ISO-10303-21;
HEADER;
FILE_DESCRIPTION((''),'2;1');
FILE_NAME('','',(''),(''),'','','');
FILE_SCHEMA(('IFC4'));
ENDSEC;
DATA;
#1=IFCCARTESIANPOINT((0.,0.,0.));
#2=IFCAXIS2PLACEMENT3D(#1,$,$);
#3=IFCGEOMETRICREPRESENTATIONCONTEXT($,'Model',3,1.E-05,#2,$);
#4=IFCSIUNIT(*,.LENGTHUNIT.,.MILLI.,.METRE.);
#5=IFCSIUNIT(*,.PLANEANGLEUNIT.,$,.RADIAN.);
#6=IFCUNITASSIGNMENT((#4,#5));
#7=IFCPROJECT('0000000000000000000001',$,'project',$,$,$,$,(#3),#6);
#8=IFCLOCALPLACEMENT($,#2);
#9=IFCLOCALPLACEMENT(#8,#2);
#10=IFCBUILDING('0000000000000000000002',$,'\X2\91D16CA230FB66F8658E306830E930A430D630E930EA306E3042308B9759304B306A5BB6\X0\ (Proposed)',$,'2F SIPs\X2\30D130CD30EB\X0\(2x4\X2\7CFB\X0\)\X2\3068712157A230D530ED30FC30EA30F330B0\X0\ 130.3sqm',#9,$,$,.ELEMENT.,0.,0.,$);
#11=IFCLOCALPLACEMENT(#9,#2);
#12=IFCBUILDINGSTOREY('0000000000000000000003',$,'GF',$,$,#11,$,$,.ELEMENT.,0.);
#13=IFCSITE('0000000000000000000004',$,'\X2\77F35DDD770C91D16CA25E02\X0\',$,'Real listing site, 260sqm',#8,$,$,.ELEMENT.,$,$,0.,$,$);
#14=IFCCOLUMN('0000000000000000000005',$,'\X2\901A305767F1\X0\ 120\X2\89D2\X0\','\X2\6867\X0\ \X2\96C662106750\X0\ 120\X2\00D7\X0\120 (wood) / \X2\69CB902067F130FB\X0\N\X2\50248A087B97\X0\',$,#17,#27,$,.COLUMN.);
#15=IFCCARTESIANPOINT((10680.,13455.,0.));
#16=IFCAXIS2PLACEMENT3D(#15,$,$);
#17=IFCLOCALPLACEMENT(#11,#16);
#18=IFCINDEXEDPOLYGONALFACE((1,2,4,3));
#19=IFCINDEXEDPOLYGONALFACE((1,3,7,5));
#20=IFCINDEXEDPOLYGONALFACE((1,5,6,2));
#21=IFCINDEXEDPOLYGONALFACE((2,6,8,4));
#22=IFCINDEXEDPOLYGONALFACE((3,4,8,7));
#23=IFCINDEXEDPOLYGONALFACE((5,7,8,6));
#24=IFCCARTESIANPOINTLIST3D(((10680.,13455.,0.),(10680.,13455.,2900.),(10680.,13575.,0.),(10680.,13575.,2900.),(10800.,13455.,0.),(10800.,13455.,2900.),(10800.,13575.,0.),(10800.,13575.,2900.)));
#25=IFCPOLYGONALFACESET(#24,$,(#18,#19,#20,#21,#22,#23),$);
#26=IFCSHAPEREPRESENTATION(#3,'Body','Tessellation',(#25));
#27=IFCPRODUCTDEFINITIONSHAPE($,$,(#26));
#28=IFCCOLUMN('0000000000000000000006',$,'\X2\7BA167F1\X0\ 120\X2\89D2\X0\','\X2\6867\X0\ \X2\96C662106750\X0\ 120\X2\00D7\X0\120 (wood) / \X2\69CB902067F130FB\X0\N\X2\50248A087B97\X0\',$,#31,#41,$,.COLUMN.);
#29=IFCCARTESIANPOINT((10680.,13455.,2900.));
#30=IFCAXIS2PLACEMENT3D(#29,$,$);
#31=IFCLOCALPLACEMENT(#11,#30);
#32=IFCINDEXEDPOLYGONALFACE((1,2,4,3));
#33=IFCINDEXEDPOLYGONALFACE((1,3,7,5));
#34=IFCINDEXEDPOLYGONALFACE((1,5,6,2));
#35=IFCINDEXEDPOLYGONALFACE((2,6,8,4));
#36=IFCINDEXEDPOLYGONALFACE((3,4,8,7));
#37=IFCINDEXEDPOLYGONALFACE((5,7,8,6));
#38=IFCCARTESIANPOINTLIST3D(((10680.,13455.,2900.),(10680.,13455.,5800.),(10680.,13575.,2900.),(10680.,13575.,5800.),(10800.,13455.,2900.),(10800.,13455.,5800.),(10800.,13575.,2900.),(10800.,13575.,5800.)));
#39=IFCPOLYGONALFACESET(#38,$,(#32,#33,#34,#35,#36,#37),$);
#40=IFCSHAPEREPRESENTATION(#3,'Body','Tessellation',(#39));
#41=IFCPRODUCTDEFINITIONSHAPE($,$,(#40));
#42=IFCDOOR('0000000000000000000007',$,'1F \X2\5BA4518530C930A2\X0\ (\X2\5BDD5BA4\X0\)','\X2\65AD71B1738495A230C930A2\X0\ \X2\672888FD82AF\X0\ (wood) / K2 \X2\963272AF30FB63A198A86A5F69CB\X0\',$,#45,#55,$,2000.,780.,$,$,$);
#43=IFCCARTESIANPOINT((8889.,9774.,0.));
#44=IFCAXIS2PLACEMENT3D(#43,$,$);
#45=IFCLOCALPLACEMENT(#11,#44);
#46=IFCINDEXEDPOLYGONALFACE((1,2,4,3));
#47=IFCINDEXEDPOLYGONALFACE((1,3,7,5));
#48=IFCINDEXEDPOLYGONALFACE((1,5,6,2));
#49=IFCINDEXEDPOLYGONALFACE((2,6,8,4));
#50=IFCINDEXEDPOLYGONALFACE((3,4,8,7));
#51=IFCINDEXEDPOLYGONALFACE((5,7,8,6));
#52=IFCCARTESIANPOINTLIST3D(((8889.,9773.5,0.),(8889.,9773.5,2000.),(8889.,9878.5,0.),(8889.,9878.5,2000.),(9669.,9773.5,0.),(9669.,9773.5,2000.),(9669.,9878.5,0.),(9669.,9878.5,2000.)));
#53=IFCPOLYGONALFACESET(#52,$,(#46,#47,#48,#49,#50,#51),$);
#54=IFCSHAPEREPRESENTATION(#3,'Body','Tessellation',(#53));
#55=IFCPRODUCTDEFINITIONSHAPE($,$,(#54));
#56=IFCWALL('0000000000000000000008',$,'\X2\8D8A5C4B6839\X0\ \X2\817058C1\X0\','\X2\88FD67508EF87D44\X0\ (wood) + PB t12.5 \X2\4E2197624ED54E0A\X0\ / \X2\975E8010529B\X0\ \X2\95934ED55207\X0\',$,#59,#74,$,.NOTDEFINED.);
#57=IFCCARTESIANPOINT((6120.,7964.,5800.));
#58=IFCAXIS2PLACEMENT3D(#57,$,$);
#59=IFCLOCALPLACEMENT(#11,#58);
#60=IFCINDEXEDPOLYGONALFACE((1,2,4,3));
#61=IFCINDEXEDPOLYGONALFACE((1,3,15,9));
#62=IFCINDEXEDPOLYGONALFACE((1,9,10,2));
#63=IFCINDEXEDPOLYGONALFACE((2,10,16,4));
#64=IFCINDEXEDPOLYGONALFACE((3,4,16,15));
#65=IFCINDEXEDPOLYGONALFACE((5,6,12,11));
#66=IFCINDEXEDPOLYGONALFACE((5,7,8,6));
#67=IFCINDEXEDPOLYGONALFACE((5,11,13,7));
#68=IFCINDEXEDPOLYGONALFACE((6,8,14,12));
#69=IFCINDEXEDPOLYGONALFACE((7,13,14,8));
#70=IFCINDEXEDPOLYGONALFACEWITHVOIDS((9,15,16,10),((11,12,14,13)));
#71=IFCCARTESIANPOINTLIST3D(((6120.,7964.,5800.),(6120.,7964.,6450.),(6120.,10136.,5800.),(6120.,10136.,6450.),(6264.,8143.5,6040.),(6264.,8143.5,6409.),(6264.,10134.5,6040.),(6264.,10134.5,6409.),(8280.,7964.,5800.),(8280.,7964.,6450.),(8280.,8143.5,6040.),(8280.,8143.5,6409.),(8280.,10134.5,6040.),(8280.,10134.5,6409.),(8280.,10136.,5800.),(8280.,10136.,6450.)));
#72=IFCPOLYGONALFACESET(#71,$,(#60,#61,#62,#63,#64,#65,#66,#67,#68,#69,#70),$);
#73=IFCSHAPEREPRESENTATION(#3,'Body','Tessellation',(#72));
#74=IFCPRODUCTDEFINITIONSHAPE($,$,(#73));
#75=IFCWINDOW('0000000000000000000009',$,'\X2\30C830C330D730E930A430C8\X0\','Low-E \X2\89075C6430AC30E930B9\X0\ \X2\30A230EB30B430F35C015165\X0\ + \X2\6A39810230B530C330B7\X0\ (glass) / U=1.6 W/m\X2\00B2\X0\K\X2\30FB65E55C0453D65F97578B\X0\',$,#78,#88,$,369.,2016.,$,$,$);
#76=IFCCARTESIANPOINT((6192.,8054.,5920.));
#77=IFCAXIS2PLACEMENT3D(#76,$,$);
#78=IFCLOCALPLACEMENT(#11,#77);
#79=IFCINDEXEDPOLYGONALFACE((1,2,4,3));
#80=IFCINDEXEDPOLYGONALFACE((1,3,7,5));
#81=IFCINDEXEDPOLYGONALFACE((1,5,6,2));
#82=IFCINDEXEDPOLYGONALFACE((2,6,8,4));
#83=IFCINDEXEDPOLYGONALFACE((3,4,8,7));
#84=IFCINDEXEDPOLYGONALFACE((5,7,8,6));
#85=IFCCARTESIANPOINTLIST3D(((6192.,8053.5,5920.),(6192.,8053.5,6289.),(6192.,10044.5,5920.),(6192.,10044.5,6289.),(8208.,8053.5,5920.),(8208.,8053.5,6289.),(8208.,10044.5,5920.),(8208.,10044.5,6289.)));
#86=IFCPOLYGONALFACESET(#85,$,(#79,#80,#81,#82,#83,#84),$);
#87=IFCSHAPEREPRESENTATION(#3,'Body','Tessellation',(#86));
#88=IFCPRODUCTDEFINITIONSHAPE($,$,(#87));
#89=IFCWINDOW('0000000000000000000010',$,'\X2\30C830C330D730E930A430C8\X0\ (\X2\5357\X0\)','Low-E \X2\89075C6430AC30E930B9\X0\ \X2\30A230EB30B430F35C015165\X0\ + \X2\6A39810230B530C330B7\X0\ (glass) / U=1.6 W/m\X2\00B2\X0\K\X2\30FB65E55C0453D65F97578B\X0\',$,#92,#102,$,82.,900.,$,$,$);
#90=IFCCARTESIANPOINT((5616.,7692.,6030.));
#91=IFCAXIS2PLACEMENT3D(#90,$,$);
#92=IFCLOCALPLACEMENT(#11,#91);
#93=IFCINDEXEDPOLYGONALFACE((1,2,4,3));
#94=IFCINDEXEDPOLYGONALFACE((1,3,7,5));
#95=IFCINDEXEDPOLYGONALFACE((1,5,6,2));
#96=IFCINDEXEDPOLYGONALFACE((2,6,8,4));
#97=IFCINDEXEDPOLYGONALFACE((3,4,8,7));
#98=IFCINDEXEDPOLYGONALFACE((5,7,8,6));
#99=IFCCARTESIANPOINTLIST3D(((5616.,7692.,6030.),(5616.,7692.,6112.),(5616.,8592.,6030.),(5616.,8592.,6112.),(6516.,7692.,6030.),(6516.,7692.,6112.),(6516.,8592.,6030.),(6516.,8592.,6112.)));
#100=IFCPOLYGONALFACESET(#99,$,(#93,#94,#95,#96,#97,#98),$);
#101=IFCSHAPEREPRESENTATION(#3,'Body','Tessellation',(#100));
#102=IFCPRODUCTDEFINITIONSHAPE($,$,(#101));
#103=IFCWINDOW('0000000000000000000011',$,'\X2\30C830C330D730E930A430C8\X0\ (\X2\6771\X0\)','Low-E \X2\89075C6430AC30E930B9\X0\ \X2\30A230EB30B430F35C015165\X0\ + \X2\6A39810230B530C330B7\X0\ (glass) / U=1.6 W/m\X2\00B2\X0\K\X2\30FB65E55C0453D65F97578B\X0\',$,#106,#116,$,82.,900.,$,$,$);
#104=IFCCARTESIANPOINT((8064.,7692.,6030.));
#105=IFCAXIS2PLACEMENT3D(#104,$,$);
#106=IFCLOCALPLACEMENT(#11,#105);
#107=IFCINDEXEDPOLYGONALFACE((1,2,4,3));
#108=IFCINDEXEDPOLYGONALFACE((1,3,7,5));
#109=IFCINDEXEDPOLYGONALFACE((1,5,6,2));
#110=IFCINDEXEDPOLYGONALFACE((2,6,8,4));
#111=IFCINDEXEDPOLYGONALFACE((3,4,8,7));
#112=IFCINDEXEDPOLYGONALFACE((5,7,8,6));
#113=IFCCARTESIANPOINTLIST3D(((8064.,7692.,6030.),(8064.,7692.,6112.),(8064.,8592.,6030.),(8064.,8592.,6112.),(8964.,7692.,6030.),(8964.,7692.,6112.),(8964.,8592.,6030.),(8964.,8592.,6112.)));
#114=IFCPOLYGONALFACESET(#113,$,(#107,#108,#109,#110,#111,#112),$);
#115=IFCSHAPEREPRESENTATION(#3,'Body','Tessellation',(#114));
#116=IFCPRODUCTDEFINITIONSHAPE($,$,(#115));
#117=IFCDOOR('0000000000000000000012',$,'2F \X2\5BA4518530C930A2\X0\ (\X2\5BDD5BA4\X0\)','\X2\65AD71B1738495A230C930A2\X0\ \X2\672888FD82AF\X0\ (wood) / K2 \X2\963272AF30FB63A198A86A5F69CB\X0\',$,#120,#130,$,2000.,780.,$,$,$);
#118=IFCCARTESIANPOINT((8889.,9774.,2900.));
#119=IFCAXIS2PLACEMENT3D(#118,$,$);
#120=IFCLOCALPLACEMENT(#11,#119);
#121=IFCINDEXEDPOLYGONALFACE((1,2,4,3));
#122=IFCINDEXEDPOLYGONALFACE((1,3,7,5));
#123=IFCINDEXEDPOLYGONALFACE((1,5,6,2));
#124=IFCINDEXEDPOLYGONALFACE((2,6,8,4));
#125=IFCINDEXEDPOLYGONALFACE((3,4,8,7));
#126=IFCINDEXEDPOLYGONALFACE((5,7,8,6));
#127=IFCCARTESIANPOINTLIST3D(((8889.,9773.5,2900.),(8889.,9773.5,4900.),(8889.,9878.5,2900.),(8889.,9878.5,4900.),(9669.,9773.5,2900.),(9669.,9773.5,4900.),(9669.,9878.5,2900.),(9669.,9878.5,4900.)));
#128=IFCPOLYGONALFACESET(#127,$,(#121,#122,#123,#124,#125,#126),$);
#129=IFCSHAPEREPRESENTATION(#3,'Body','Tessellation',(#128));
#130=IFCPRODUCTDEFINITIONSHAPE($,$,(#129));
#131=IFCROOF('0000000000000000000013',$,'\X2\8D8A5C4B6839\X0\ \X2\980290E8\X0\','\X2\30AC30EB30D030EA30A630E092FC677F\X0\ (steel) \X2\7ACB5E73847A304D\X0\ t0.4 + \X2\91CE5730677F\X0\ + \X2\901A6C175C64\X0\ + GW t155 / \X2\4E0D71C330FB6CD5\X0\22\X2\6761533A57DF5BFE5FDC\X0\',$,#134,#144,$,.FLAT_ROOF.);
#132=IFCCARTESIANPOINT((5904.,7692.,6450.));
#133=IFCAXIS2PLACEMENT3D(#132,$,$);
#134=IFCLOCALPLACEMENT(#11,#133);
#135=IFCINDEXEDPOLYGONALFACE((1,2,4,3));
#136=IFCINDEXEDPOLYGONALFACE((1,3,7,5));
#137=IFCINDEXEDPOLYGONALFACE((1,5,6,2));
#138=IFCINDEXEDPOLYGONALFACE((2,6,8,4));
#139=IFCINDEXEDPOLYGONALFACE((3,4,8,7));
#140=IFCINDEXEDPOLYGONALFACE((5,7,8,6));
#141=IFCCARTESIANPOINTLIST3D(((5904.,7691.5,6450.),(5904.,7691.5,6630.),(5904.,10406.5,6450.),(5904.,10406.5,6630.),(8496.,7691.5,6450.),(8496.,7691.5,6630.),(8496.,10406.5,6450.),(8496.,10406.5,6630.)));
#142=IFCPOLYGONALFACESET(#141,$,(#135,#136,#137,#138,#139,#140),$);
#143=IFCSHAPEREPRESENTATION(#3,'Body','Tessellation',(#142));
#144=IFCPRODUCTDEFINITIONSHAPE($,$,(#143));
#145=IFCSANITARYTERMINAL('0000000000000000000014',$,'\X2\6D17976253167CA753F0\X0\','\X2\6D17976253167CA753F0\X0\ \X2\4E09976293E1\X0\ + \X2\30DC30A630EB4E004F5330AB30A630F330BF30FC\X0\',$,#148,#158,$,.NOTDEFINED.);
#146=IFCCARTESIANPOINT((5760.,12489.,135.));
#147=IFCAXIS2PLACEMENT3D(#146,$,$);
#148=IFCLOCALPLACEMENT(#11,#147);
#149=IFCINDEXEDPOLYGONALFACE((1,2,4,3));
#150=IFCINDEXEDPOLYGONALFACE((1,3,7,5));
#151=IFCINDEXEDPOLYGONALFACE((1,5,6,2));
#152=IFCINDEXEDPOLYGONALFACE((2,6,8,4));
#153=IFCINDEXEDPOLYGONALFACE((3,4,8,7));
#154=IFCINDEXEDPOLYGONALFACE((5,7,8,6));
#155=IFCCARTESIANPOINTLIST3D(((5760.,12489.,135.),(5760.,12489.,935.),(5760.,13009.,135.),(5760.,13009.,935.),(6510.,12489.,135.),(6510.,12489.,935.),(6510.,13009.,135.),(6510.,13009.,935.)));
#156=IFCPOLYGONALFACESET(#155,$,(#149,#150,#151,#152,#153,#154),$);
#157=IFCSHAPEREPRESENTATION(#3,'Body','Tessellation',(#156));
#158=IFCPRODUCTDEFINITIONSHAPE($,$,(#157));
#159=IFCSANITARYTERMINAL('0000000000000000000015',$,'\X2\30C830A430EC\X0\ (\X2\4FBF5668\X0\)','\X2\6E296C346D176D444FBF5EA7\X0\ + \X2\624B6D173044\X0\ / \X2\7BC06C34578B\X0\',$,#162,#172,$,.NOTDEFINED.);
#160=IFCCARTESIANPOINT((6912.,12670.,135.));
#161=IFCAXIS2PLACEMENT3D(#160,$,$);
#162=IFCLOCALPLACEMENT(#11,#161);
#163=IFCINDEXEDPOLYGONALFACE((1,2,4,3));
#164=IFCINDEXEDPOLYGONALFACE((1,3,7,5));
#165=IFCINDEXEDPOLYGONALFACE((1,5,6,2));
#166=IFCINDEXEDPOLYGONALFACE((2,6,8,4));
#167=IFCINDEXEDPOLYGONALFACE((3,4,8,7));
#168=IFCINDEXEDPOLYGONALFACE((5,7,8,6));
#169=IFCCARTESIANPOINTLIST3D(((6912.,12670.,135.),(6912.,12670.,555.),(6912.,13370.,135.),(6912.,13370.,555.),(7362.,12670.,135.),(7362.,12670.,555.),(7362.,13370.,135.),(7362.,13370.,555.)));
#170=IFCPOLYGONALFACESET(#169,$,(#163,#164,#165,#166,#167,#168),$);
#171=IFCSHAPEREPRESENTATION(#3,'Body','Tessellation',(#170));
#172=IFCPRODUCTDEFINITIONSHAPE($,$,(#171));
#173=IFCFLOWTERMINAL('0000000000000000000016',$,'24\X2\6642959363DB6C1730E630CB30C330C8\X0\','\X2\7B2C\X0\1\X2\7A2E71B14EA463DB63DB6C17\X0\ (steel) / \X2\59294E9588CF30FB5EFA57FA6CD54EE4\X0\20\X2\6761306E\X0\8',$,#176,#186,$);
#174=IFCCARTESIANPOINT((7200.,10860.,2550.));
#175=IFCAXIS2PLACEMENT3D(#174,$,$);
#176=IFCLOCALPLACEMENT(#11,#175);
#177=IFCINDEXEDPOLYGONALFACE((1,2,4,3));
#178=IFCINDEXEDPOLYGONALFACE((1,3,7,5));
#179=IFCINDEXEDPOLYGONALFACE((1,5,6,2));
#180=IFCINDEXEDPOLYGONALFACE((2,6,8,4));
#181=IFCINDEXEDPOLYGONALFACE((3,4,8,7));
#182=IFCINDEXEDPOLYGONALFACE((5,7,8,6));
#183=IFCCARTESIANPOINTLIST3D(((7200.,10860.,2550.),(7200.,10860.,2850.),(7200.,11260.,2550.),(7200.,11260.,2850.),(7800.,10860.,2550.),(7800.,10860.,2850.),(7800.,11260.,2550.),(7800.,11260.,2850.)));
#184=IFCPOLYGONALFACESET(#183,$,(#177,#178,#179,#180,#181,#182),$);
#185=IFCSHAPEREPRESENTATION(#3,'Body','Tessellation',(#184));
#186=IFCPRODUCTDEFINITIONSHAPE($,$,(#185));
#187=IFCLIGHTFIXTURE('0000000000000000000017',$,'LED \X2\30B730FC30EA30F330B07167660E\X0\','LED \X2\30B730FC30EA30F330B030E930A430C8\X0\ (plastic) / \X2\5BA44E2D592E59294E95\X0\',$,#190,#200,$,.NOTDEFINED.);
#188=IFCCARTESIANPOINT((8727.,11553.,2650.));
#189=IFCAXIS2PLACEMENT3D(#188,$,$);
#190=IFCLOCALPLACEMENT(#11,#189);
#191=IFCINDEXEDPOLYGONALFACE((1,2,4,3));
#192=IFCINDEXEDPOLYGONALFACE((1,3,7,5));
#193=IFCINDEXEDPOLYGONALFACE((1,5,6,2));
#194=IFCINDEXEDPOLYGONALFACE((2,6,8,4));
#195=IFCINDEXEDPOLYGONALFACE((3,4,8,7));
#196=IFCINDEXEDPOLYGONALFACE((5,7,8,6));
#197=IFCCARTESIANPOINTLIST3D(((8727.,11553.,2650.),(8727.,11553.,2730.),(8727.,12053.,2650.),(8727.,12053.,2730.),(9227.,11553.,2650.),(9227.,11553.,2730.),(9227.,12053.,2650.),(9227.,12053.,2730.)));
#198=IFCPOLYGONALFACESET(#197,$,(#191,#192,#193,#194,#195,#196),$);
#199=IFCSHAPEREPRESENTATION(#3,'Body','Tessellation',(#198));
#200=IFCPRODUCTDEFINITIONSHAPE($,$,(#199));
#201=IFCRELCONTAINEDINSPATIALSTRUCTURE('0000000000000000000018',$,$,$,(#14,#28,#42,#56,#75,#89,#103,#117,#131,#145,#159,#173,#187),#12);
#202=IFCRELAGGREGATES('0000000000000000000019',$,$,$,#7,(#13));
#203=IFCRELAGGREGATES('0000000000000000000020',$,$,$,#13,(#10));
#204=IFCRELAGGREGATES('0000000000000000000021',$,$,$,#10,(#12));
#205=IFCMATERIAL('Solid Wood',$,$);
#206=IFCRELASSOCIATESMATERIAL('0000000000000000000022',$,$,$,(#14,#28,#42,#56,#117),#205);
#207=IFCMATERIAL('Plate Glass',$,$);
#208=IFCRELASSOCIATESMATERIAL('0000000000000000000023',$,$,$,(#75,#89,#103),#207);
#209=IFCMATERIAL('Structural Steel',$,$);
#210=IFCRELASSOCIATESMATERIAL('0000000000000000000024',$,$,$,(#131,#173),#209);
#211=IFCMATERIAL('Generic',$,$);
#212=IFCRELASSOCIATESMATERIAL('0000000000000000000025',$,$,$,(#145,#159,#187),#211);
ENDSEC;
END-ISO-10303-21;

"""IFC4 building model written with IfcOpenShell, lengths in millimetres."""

from ifc_helpers import new_model, si_unit, frame, frame_2d, origin, place, context, project, spatial, rectangle, extrude, material, element, fill, save


model = new_model("IFC4")

# Units and contexts
model_context = context("Model", 3, precision=1e-05, world=origin())
ifc_project = project(units=[si_unit("LENGTHUNIT", "METRE", prefix="MILLI"), si_unit("PLANEANGLEUNIT", "RADIAN")], contexts=[model_context])

# Site, building, storey
site_placement = place(None, origin())
site = spatial("IfcSite", under=ifc_project, at=site_placement, Name="石川県金沢市", ObjectType="Real listing site, 260sqm", CompositionType="ELEMENT", RefElevation=0.0)
building_placement = place(site_placement, origin())
building = spatial("IfcBuilding", under=site, at=building_placement, Name="金沢・書斎とライブラリのある静かな家 (Proposed)", ObjectType="2F SIPsパネル(2x4系)と無垢フローリング 130.3sqm", CompositionType="ELEMENT", ElevationOfRefHeight=0.0, ElevationOfTerrain=0.0)
storey_placement = place(building_placement, origin())
storey = spatial("IfcBuildingStorey", under=building, at=storey_placement, Name="GF", CompositionType="ELEMENT", Elevation=0.0)

# Columns
ifc_material_1 = material(Name="Solid Wood")
column_1_placement = place(storey_placement, frame((10680.0, 13455.0, 0.0)))
element("IfcColumn", 1, at=column_1_placement, inside=storey, material=ifc_material_1, Name="通し柱 120角", Description="桧 集成材 120×120 (wood) / 構造柱・N値計算", PredefinedType="COLUMN", context=model_context, shape_type="SweptSolid", body=[
    extrude(rectangle(XDim=120.0, YDim=120.0, at=frame_2d((60.0, 60.0))), frame((10680.0, 13455.0, 0.0)), (0.0, 0.0, 1.0), 2900.0),
])
column_2_placement = place(storey_placement, frame((10680.0, 13455.0, 2900.0)))
element("IfcColumn", 2, at=column_2_placement, inside=storey, material=ifc_material_1, Name="管柱 120角", Description="桧 集成材 120×120 (wood) / 構造柱・N値計算", PredefinedType="COLUMN", context=model_context, shape_type="SweptSolid", body=[
    extrude(rectangle(XDim=120.0, YDim=120.0, at=frame_2d((60.0, 60.0))), frame((10680.0, 13455.0, 2900.0)), (0.0, 0.0, 1.0), 2900.0),
])

# Door
door_1_placement = place(storey_placement, frame((8889.0, 9774.0, 0.0)))
element("IfcDoor", 3, at=door_1_placement, inside=storey, material=ifc_material_1, Name="1F 室内ドア (寝室)", Description="断熱玄関ドア 木製芯 (wood) / K2 防犯・採風機構", OverallHeight=2000.0, OverallWidth=780.0, context=model_context, shape_type="SweptSolid", body=[
    extrude(rectangle(XDim=780.0, YDim=105.0, at=frame_2d((390.0, 52.0))), frame((8889.0, 9774.0, 0.0)), (0.0, 0.0, 1.0), 2000.0),
])

# Wall, openings, windows
wall_1_placement = place(storey_placement, frame((6120.0, 7964.0, 5800.0)))
wall_1 = element("IfcWall", 4, at=wall_1_placement, inside=storey, material=ifc_material_1, Name="越屋根 腰壁", Description="製材軸組 (wood) + PB t12.5 両面仕上 / 非耐力 間仕切", PredefinedType="NOTDEFINED", context=model_context, shape_type="SweptSolid", body=[
    extrude(rectangle(XDim=2160.0, YDim=2172.0, at=frame_2d((1080.0, 1086.0))), frame((6120.0, 7964.0, 5800.0)), (0.0, 0.0, 1.0), 650.0),
])
opening_1_placement = place(storey_placement, frame((6192.0, 8054.0, 5920.0)))
opening_1 = element("IfcOpeningElement", 5, at=opening_1_placement, cuts=wall_1, PredefinedType="NOTDEFINED", context=model_context, shape_type="SweptSolid", body=[
    extrude(rectangle(XDim=2016.0, YDim=1991.0, at=frame_2d((1008.0, 995.0))), frame((6192.0, 8054.0, 5920.0)), (0.0, 0.0, 1.0), 369.0),
])
opening_2_placement = place(storey_placement, frame((5616.0, 7692.0, 6030.0)))
opening_2 = element("IfcOpeningElement", 6, at=opening_2_placement, cuts=wall_1, PredefinedType="NOTDEFINED", context=model_context, shape_type="SweptSolid", body=[
    extrude(rectangle(XDim=900.0, YDim=900.0, at=frame_2d((450.0, 450.0))), frame((5616.0, 7692.0, 6030.0)), (0.0, 0.0, 1.0), 82.0),
])
opening_3_placement = place(storey_placement, frame((8064.0, 7692.0, 6030.0)))
opening_3 = element("IfcOpeningElement", 7, at=opening_3_placement, cuts=wall_1, PredefinedType="NOTDEFINED", context=model_context, shape_type="SweptSolid", body=[
    extrude(rectangle(XDim=900.0, YDim=900.0, at=frame_2d((450.0, 450.0))), frame((8064.0, 7692.0, 6030.0)), (0.0, 0.0, 1.0), 82.0),
])
ifc_material_2 = material(Name="Plate Glass")
window_1_placement = place(storey_placement, frame((6192.0, 8054.0, 5920.0)))
window_1 = element("IfcWindow", 8, at=window_1_placement, inside=storey, material=ifc_material_2, Name="トップライト", Description="Low-E 複層ガラス アルゴン封入 + 樹脂サッシ (glass) / U=1.6 W/m²K・日射取得型", OverallHeight=369.0, OverallWidth=2016.0, context=model_context, shape_type="SweptSolid", body=[
    extrude(rectangle(XDim=2016.0, YDim=1991.0, at=frame_2d((1008.0, 995.0))), frame((6192.0, 8054.0, 5920.0)), (0.0, 0.0, 1.0), 369.0),
])
fill(opening_1, window_1)
window_2_placement = place(storey_placement, frame((5616.0, 7692.0, 6030.0)))
window_2 = element("IfcWindow", 9, at=window_2_placement, inside=storey, material=ifc_material_2, Name="トップライト (南)", Description="Low-E 複層ガラス アルゴン封入 + 樹脂サッシ (glass) / U=1.6 W/m²K・日射取得型", OverallHeight=82.0, OverallWidth=900.0, context=model_context, shape_type="SweptSolid", body=[
    extrude(rectangle(XDim=900.0, YDim=900.0, at=frame_2d((450.0, 450.0))), frame((5616.0, 7692.0, 6030.0)), (0.0, 0.0, 1.0), 82.0),
])
fill(opening_2, window_2)
window_3_placement = place(storey_placement, frame((8064.0, 7692.0, 6030.0)))
window_3 = element("IfcWindow", 10, at=window_3_placement, inside=storey, material=ifc_material_2, Name="トップライト (東)", Description="Low-E 複層ガラス アルゴン封入 + 樹脂サッシ (glass) / U=1.6 W/m²K・日射取得型", OverallHeight=82.0, OverallWidth=900.0, context=model_context, shape_type="SweptSolid", body=[
    extrude(rectangle(XDim=900.0, YDim=900.0, at=frame_2d((450.0, 450.0))), frame((8064.0, 7692.0, 6030.0)), (0.0, 0.0, 1.0), 82.0),
])
fill(opening_3, window_3)

# Door
door_2_placement = place(storey_placement, frame((8889.0, 9774.0, 2900.0)))
element("IfcDoor", 11, at=door_2_placement, inside=storey, material=ifc_material_1, Name="2F 室内ドア (寝室)", Description="断熱玄関ドア 木製芯 (wood) / K2 防犯・採風機構", OverallHeight=2000.0, OverallWidth=780.0, context=model_context, shape_type="SweptSolid", body=[
    extrude(rectangle(XDim=780.0, YDim=105.0, at=frame_2d((390.0, 52.0))), frame((8889.0, 9774.0, 2900.0)), (0.0, 0.0, 1.0), 2000.0),
])

# Roof
ifc_material_3 = material(Name="Structural Steel")
roof_placement = place(storey_placement, frame((5904.0, 7692.0, 6450.0)))
element("IfcRoof", 12, at=roof_placement, inside=storey, material=ifc_material_3, Name="越屋根 頂部", Description="ガルバリウム鋼板 (steel) 立平葺き t0.4 + 野地板 + 通気層 + GW t155 / 不燃・法22条区域対応", PredefinedType="FLAT_ROOF", context=model_context, shape_type="SweptSolid", body=[
    extrude(rectangle(XDim=2592.0, YDim=2715.0, at=frame_2d((1296.0, 1357.0))), frame((5904.0, 7692.0, 6450.0)), (0.0, 0.0, 1.0), 180.0),
])

# Sanitary terminals
ifc_material_4 = material(Name="Generic")
sanitary_terminal_1_placement = place(storey_placement, frame((5760.0, 12489.0, 135.0)))
element("IfcSanitaryTerminal", 13, at=sanitary_terminal_1_placement, inside=storey, material=ifc_material_4, Name="洗面化粧台", Description="洗面化粧台 三面鏡 + ボウル一体カウンター", PredefinedType="NOTDEFINED", context=model_context, shape_type="SweptSolid", body=[
    extrude(rectangle(XDim=750.0, YDim=520.0, at=frame_2d((375.0, 260.0))), frame((5760.0, 12489.0, 135.0)), (0.0, 0.0, 1.0), 800.0),
])
sanitary_terminal_2_placement = place(storey_placement, frame((6912.0, 12670.0, 135.0)))
element("IfcSanitaryTerminal", 14, at=sanitary_terminal_2_placement, inside=storey, material=ifc_material_4, Name="トイレ (便器)", Description="温水洗浄便座 + 手洗い / 節水型", PredefinedType="NOTDEFINED", context=model_context, shape_type="SweptSolid", body=[
    extrude(rectangle(XDim=450.0, YDim=700.0, at=frame_2d((225.0, 350.0))), frame((6912.0, 12670.0, 135.0)), (0.0, 0.0, 1.0), 420.0),
])

# Flow terminal
flow_terminal_placement = place(storey_placement, frame((7200.0, 10860.0, 2550.0)))
element("IfcFlowTerminal", 15, at=flow_terminal_placement, inside=storey, material=ifc_material_3, Name="24時間換気ユニット", Description="第1種熱交換換気 (steel) / 天井裏・建基法令20条の8", context=model_context, shape_type="SweptSolid", body=[
    extrude(rectangle(XDim=600.0, YDim=400.0, at=frame_2d((300.0, 200.0))), frame((7200.0, 10860.0, 2550.0)), (0.0, 0.0, 1.0), 300.0),
])

# Light fixture
light_fixture_1_placement = place(storey_placement, frame((8727.0, 11553.0, 2650.0)))
element("IfcLightFixture", 16, at=light_fixture_1_placement, inside=storey, material=ifc_material_4, Name="LED シーリング照明", Description="LED シーリングライト (plastic) / 室中央天井", PredefinedType="NOTDEFINED", context=model_context, shape_type="SweptSolid", body=[
    extrude(rectangle(XDim=500.0, YDim=500.0, at=frame_2d((250.0, 250.0))), frame((8727.0, 11553.0, 2650.0)), (0.0, 0.0, 1.0), 80.0),
])

save(model, "model.ifc")
